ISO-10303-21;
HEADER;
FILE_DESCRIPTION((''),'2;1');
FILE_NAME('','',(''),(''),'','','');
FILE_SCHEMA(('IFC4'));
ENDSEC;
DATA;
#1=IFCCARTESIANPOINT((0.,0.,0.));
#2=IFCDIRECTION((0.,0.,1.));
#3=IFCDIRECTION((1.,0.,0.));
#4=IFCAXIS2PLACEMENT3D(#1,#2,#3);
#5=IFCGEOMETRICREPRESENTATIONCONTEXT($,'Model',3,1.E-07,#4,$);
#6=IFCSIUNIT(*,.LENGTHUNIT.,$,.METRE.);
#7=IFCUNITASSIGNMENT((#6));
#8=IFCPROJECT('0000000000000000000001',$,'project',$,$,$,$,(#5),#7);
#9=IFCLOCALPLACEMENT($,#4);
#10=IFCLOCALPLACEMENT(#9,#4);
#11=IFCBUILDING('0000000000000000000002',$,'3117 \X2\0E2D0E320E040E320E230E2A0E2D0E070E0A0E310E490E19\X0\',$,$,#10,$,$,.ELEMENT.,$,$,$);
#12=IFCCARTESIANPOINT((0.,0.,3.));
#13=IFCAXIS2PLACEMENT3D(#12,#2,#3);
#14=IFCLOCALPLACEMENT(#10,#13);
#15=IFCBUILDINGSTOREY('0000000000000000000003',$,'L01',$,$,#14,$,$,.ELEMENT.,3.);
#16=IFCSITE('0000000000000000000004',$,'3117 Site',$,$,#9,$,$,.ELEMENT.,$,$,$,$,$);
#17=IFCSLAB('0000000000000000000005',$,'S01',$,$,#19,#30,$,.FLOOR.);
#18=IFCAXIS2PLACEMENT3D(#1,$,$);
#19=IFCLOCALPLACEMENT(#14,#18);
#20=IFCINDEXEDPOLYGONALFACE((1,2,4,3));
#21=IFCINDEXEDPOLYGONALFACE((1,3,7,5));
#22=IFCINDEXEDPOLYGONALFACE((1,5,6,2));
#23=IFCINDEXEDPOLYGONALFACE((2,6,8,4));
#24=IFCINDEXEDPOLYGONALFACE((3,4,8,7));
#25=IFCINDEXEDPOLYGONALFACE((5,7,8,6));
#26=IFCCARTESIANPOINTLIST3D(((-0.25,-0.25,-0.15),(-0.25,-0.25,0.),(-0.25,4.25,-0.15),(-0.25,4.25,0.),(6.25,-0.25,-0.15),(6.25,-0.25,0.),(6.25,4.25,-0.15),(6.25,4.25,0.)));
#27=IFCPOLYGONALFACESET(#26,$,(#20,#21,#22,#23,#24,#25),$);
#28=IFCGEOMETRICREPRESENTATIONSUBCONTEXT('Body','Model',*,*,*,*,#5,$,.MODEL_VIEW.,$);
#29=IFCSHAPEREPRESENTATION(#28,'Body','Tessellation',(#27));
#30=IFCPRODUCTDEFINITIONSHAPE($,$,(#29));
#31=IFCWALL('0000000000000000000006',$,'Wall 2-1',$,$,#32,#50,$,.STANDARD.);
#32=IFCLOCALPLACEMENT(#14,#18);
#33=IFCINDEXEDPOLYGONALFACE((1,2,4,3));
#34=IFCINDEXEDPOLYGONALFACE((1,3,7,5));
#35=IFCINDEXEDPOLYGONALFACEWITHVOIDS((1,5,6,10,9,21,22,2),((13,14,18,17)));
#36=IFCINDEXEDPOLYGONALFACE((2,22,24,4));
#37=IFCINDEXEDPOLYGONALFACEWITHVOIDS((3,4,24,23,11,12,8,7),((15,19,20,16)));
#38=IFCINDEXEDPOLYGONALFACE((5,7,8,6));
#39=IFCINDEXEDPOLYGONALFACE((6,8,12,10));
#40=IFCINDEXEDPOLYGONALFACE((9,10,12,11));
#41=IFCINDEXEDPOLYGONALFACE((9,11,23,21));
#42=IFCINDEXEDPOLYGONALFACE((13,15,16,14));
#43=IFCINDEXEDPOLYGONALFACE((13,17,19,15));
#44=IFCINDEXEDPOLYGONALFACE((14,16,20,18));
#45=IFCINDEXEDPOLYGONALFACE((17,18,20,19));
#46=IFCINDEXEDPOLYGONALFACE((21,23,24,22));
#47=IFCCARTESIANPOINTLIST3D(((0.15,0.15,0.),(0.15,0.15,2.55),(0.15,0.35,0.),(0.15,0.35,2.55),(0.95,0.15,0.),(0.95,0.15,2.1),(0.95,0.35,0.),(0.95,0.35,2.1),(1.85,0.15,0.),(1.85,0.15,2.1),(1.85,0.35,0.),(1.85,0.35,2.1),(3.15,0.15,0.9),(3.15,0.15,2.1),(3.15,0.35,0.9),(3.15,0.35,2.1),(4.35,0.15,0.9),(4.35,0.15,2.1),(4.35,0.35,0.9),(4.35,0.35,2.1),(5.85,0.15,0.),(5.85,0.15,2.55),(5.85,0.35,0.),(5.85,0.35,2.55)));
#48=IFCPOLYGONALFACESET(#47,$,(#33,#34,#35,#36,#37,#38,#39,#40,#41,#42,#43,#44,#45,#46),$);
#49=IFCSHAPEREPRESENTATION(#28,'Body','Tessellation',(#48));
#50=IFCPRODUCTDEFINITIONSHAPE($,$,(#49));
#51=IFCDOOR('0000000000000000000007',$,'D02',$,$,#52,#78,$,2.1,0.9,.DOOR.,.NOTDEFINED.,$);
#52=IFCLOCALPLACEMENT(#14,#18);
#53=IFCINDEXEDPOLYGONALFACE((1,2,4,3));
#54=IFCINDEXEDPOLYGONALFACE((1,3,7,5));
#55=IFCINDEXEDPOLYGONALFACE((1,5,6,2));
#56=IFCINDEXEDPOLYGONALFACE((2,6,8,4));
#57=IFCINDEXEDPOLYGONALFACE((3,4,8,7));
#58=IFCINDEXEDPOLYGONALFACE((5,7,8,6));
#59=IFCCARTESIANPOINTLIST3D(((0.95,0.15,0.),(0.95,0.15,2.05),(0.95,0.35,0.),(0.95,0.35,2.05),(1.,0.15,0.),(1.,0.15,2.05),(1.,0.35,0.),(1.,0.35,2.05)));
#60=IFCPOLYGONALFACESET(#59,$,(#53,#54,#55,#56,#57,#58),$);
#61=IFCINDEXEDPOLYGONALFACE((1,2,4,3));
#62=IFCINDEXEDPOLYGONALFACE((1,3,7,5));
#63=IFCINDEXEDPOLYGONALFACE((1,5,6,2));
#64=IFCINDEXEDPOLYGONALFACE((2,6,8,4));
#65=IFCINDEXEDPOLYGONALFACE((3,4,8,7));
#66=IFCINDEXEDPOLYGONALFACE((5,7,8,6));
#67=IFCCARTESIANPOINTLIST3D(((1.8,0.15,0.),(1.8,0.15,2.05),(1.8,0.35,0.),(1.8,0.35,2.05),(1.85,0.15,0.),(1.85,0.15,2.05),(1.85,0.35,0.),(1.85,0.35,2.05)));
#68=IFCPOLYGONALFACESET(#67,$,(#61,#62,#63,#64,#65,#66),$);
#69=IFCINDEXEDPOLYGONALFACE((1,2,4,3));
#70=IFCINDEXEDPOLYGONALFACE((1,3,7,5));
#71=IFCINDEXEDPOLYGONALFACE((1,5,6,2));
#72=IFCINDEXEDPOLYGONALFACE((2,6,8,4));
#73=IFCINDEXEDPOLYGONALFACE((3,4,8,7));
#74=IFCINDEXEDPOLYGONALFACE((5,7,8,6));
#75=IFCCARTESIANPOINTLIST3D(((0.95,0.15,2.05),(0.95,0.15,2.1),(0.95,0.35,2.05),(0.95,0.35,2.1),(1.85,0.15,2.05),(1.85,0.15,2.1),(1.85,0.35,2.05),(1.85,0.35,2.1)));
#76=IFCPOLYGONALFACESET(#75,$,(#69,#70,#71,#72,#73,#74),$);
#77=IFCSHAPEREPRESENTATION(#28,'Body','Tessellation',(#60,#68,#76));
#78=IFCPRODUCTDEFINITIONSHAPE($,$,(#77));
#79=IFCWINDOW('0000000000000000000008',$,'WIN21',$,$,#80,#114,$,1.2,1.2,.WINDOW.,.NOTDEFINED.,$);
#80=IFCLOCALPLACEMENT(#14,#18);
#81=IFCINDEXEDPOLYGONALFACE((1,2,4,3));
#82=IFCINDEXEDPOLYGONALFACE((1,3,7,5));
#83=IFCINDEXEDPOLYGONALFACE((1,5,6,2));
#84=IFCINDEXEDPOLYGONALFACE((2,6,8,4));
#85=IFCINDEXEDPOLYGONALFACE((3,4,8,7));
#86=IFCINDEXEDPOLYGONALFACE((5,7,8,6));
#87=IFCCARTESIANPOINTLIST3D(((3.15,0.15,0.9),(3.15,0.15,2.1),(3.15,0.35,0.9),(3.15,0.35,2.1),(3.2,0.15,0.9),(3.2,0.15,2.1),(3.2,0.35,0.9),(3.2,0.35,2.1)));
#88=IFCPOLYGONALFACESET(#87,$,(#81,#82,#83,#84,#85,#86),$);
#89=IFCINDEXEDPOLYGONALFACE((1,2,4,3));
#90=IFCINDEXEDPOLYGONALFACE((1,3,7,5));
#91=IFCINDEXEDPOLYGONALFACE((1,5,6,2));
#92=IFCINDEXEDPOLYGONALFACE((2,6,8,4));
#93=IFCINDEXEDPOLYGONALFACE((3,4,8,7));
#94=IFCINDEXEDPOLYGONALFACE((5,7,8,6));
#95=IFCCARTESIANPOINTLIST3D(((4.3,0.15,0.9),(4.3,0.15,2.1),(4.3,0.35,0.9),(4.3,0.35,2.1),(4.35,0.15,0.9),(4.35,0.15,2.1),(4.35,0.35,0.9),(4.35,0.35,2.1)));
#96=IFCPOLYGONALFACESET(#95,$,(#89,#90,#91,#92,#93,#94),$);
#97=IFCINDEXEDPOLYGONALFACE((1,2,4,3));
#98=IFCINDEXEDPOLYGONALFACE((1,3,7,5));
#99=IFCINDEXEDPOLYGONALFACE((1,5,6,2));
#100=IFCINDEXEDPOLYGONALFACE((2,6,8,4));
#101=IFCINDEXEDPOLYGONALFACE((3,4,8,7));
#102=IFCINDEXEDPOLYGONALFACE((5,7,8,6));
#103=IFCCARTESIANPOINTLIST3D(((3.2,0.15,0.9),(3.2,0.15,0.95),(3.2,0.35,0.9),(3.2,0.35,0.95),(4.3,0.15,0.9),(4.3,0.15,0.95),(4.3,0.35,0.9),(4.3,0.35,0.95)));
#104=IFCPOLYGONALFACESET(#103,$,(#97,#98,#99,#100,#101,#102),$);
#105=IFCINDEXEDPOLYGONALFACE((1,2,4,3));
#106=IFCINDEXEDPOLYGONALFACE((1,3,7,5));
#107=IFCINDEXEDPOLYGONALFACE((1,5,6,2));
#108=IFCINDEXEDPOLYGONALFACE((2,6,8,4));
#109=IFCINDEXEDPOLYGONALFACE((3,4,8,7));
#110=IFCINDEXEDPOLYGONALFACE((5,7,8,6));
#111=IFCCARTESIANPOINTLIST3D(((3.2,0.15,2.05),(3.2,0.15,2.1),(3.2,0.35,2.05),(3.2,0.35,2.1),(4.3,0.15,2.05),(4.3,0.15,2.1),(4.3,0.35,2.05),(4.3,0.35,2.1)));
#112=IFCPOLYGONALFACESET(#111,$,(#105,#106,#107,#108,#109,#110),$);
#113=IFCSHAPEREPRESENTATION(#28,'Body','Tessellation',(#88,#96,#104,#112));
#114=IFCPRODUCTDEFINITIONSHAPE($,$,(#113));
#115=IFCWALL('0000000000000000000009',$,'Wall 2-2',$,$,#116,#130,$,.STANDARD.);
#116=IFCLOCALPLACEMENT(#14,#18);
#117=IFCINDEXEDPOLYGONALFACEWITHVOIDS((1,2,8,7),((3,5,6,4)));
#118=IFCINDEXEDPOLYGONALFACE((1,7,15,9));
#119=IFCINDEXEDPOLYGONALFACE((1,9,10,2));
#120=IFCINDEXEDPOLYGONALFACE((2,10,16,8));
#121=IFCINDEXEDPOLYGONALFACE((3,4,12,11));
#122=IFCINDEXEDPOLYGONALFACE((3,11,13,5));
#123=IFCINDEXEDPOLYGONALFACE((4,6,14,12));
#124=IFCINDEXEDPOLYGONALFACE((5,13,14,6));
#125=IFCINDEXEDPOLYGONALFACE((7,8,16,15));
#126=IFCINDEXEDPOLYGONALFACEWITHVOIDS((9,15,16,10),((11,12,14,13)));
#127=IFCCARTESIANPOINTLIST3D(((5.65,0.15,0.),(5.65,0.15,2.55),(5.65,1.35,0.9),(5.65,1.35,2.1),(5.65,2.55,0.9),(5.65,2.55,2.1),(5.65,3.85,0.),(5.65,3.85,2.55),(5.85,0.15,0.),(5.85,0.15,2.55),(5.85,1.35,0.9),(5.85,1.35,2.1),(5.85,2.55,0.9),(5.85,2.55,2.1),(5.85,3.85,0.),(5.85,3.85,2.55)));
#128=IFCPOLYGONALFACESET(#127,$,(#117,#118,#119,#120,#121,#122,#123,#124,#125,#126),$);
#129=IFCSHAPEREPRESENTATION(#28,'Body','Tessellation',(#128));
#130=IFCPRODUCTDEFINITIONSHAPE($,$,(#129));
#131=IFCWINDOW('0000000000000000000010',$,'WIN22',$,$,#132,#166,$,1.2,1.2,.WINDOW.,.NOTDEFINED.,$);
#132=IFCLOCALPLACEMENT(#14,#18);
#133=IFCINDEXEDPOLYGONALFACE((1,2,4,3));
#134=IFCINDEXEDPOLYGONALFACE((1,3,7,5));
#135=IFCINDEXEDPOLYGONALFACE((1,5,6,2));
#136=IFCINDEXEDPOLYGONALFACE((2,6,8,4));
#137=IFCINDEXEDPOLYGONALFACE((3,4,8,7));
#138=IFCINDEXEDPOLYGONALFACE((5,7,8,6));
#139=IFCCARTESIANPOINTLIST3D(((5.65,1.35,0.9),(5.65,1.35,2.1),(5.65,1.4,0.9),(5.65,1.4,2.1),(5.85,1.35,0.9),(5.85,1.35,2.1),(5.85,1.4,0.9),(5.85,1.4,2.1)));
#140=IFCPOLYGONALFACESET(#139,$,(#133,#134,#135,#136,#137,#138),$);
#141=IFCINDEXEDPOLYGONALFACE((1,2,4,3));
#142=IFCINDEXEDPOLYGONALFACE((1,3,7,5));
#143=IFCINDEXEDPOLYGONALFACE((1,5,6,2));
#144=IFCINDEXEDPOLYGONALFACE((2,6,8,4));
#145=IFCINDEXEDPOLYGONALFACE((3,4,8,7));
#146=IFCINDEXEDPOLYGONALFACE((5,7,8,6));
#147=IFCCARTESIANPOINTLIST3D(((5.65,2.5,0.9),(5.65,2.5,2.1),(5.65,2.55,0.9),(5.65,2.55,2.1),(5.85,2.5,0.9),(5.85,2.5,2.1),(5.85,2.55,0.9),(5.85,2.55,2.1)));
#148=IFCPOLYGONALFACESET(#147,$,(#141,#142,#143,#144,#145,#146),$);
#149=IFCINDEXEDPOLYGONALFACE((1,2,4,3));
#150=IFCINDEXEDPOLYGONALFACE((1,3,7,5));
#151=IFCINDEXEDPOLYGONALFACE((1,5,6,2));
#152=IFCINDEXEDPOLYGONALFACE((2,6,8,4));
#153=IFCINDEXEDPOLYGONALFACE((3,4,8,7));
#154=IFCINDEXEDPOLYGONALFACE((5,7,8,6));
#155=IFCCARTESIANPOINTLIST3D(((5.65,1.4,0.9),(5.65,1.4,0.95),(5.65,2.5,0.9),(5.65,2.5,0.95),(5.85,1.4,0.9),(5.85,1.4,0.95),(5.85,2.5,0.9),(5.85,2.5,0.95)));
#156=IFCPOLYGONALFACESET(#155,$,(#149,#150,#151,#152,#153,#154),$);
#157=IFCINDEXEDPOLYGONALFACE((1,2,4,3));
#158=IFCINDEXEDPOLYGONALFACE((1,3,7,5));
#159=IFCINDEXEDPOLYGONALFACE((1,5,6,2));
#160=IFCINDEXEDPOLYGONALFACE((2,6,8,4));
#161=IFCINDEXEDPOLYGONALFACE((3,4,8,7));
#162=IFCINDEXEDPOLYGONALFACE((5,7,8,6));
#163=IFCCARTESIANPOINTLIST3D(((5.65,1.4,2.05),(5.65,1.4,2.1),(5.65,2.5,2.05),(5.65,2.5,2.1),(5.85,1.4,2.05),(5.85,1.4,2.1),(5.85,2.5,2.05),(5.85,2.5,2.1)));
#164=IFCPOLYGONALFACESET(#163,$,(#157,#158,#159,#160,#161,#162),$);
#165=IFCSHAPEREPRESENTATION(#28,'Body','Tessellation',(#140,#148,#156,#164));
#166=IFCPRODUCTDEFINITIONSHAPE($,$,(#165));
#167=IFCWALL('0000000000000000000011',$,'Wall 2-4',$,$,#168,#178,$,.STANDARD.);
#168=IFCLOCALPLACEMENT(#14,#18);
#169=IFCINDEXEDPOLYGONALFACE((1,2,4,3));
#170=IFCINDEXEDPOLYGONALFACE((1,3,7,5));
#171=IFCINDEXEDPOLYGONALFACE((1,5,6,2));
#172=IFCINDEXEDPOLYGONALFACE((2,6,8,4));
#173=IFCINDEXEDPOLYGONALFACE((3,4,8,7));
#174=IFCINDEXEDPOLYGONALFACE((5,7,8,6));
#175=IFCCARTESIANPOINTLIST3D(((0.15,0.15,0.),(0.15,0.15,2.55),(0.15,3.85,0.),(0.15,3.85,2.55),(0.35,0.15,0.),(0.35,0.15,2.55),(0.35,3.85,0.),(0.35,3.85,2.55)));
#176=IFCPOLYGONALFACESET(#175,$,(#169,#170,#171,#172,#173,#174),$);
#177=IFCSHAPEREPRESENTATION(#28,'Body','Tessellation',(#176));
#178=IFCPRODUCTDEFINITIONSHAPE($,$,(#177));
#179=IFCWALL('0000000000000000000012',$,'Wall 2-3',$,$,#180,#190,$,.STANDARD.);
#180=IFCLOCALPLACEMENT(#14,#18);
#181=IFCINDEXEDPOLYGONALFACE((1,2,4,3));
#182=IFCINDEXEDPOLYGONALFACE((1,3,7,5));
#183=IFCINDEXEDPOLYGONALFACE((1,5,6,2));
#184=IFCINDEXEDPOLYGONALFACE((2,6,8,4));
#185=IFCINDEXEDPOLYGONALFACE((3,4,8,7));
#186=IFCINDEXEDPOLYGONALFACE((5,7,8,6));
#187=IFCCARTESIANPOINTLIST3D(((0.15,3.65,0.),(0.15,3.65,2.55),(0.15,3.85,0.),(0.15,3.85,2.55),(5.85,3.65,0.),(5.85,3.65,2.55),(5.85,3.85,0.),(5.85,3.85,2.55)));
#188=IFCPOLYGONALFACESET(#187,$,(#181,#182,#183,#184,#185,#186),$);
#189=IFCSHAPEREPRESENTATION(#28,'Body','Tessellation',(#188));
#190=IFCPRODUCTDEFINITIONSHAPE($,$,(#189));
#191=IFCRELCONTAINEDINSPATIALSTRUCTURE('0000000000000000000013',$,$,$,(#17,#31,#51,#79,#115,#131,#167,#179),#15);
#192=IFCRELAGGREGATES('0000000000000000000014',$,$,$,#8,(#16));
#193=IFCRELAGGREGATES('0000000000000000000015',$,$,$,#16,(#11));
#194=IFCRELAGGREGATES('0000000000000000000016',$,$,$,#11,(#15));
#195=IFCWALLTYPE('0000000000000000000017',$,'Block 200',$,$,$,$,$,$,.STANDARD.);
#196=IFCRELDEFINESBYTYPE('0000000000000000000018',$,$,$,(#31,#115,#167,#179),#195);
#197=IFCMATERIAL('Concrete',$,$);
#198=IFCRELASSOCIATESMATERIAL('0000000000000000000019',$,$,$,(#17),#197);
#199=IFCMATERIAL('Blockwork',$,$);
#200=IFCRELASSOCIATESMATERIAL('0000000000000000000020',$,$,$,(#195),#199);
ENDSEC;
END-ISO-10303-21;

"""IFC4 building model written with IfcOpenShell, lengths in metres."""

from ifc_helpers import new_model, si_unit, frame, origin_with_axes, place, context, subcontext, project, spatial, polyline, outline, extrude, material, type_object, element, fill, save


model = new_model("IFC4")

# Units and contexts
model_context = context("Model", 3, precision=1e-07, world=origin_with_axes())
body_context = subcontext(model_context, "Body", "Model", "MODEL_VIEW")
ifc_project = project(units=[si_unit("LENGTHUNIT", "METRE")], contexts=[model_context])

# Site, building, storey
site_placement = place(None, origin_with_axes())
site = spatial("IfcSite", under=ifc_project, at=site_placement, Name="3117 Site", CompositionType="ELEMENT")
building_placement = place(site_placement, origin_with_axes())
building = spatial("IfcBuilding", under=site, at=building_placement, Name="3117 อาคารสองชั้น", CompositionType="ELEMENT")
storey_placement = place(building_placement, frame((0.0, 0.0, 3.0), z_axis=(0.0, 0.0, 1.0), x_axis=(1.0, 0.0, 0.0)))
storey = spatial("IfcBuildingStorey", under=building, at=storey_placement, Name="L01", CompositionType="ELEMENT", Elevation=3.0)

# Slab
ifc_material_1 = material(Name="Concrete")
slab_placement = place(storey_placement, frame((0.0, 0.0, -0.15), z_axis=(0.0, 0.0, 1.0), x_axis=(1.0, 0.0, 0.0)))
element("IfcSlab", 1, at=slab_placement, inside=storey, material=ifc_material_1, Name="S01", PredefinedType="FLOOR", context=body_context, shape_type="SweptSolid", body=[
    extrude(outline(polyline([(-0.25, -0.25), (6.25, -0.25), (6.25, 4.25), (-0.25, 4.25), (-0.25, -0.25)])), origin_with_axes(), (0.0, 0.0, 1.0), 0.15),
])

# Wall, openings, door, window
ifc_material_2 = material(Name="Blockwork")
wall_type = type_object("IfcWallType", Name="Block 200", PredefinedType="STANDARD", material=ifc_material_2)
wall_1_placement = place(storey_placement, frame((0.15, 0.15, 0.0), z_axis=(0.0, 0.0, 1.0), x_axis=(1.0, 0.0, 0.0)))
wall_1 = element("IfcWall", 2, at=wall_1_placement, inside=storey, type_object=wall_type, Name="Wall 2-1", PredefinedType="STANDARD", context=body_context, shape_type="SweptSolid", body=[
    extrude(outline(polyline([(0.0, 0.0), (5.7, 0.0), (5.7, 0.2), (0.0, 0.2), (0.0, 0.0)])), origin_with_axes(), (0.0, 0.0, 1.0), 2.55),
])
opening_1_placement = place(wall_1_placement, frame((0.8, 0.0, 0.0), z_axis=(0.0, 0.0, 1.0), x_axis=(1.0, 0.0, 0.0)))
opening_1 = element("IfcOpeningElement", 3, at=opening_1_placement, cuts=wall_1, PredefinedType="OPENING", context=body_context, shape_type="SweptSolid", body=[
    extrude(outline(polyline([(0.0, 0.0), (0.9, 0.0), (0.9, 0.2), (0.0, 0.2), (0.0, 0.0)])), origin_with_axes(), (0.0, 0.0, 1.0), 2.1),
])
opening_2_placement = place(wall_1_placement, frame((3.0, 0.0, 0.9), z_axis=(0.0, 0.0, 1.0), x_axis=(1.0, 0.0, 0.0)))
opening_2 = element("IfcOpeningElement", 4, at=opening_2_placement, cuts=wall_1, PredefinedType="OPENING", context=body_context, shape_type="SweptSolid", body=[
    extrude(outline(polyline([(0.0, 0.0), (1.2, 0.0), (1.2, 0.2), (0.0, 0.2), (0.0, 0.0)])), origin_with_axes(), (0.0, 0.0, 1.0), 1.2),
])
door_placement = place(opening_1_placement, frame((0.0, 0.0, 0.0), z_axis=(0.0, 0.0, 1.0), x_axis=(1.0, 0.0, 0.0)))
door = element("IfcDoor", 5, at=door_placement, inside=storey, Name="D02", OperationType="NOTDEFINED", OverallHeight=2.1, OverallWidth=0.9, PredefinedType="DOOR", context=body_context, shape_type="SweptSolid", body=[
    extrude(outline(polyline([(0.0, 0.0), (0.05, 0.0), (0.05, 0.2), (0.0, 0.2), (0.0, 0.0)])), origin_with_axes(), (0.0, 0.0, 1.0), 2.05),
    extrude(outline(polyline([(0.0, 0.0), (0.05, 0.0), (0.05, 0.2), (0.0, 0.2), (0.0, 0.0)])), frame((0.85, 0.0, 0.0), z_axis=(0.0, 0.0, 1.0), x_axis=(1.0, 0.0, 0.0)), (0.0, 0.0, 1.0), 2.05),
    extrude(outline(polyline([(0.0, 0.0), (0.9, 0.0), (0.9, 0.2), (0.0, 0.2), (0.0, 0.0)])), frame((0.0, 0.0, 2.05), z_axis=(0.0, 0.0, 1.0), x_axis=(1.0, 0.0, 0.0)), (0.0, 0.0, 1.0), 0.05),
])
fill(opening_1, door)
window_1_placement = place(opening_2_placement, frame((0.0, 0.0, 0.0), z_axis=(0.0, 0.0, 1.0), x_axis=(1.0, 0.0, 0.0)))
window_1 = element("IfcWindow", 6, at=window_1_placement, inside=storey, Name="WIN21", OverallHeight=1.2, OverallWidth=1.2, PartitioningType="NOTDEFINED", PredefinedType="WINDOW", context=body_context, shape_type="SweptSolid", body=[
    extrude(outline(polyline([(0.0, 0.0), (0.05, 0.0), (0.05, 0.2), (0.0, 0.2), (0.0, 0.0)])), origin_with_axes(), (0.0, 0.0, 1.0), 1.2),
    extrude(outline(polyline([(0.0, 0.0), (0.05, 0.0), (0.05, 0.2), (0.0, 0.2), (0.0, 0.0)])), frame((1.15, 0.0, 0.0), z_axis=(0.0, 0.0, 1.0), x_axis=(1.0, 0.0, 0.0)), (0.0, 0.0, 1.0), 1.2),
    extrude(outline(polyline([(0.0, 0.0), (1.1, 0.0), (1.1, 0.2), (0.0, 0.2), (0.0, 0.0)])), frame((0.05, 0.0, 0.0), z_axis=(0.0, 0.0, 1.0), x_axis=(1.0, 0.0, 0.0)), (0.0, 0.0, 1.0), 0.05),
    extrude(outline(polyline([(0.0, 0.0), (1.1, 0.0), (1.1, 0.2), (0.0, 0.2), (0.0, 0.0)])), frame((0.05, 0.0, 1.15), z_axis=(0.0, 0.0, 1.0), x_axis=(1.0, 0.0, 0.0)), (0.0, 0.0, 1.0), 0.05),
])
fill(opening_2, window_1)

# Wall, opening, window
wall_2_placement = place(storey_placement, frame((5.85, 0.15, 0.0), z_axis=(0.0, 0.0, 1.0), x_axis=(0.0, 1.0, 0.0)))
wall_2 = element("IfcWall", 7, at=wall_2_placement, inside=storey, type_object=wall_type, Name="Wall 2-2", PredefinedType="STANDARD", context=body_context, shape_type="SweptSolid", body=[
    extrude(outline(polyline([(0.0, 0.0), (3.7, 0.0), (3.7, 0.2), (0.0, 0.2), (0.0, 0.0)])), origin_with_axes(), (0.0, 0.0, 1.0), 2.55),
])
opening_3_placement = place(wall_2_placement, frame((1.2, 0.0, 0.9), z_axis=(0.0, 0.0, 1.0), x_axis=(1.0, 0.0, 0.0)))
opening_3 = element("IfcOpeningElement", 8, at=opening_3_placement, cuts=wall_2, PredefinedType="OPENING", context=body_context, shape_type="SweptSolid", body=[
    extrude(outline(polyline([(0.0, 0.0), (1.2, 0.0), (1.2, 0.2), (0.0, 0.2), (0.0, 0.0)])), origin_with_axes(), (0.0, 0.0, 1.0), 1.2),
])
window_2_placement = place(opening_3_placement, frame((0.0, 0.0, 0.0), z_axis=(0.0, 0.0, 1.0), x_axis=(1.0, 0.0, 0.0)))
window_2 = element("IfcWindow", 9, at=window_2_placement, inside=storey, Name="WIN22", OverallHeight=1.2, OverallWidth=1.2, PartitioningType="NOTDEFINED", PredefinedType="WINDOW", context=body_context, shape_type="SweptSolid", body=[
    extrude(outline(polyline([(0.0, 0.0), (0.05, 0.0), (0.05, 0.2), (0.0, 0.2), (0.0, 0.0)])), origin_with_axes(), (0.0, 0.0, 1.0), 1.2),
    extrude(outline(polyline([(0.0, 0.0), (0.05, 0.0), (0.05, 0.2), (0.0, 0.2), (0.0, 0.0)])), frame((1.15, 0.0, 0.0), z_axis=(0.0, 0.0, 1.0), x_axis=(1.0, 0.0, 0.0)), (0.0, 0.0, 1.0), 1.2),
    extrude(outline(polyline([(0.0, 0.0), (1.1, 0.0), (1.1, 0.2), (0.0, 0.2), (0.0, 0.0)])), frame((0.05, 0.0, 0.0), z_axis=(0.0, 0.0, 1.0), x_axis=(1.0, 0.0, 0.0)), (0.0, 0.0, 1.0), 0.05),
    extrude(outline(polyline([(0.0, 0.0), (1.1, 0.0), (1.1, 0.2), (0.0, 0.2), (0.0, 0.0)])), frame((0.05, 0.0, 1.15), z_axis=(0.0, 0.0, 1.0), x_axis=(1.0, 0.0, 0.0)), (0.0, 0.0, 1.0), 0.05),
])
fill(opening_3, window_2)

# Walls
wall_3_placement = place(storey_placement, frame((0.15, 3.85, 0.0), z_axis=(0.0, 0.0, 1.0), x_axis=(0.0, -1.0, 0.0)))
element("IfcWall", 10, at=wall_3_placement, inside=storey, type_object=wall_type, Name="Wall 2-4", PredefinedType="STANDARD", context=body_context, shape_type="SweptSolid", body=[
    extrude(outline(polyline([(0.0, 0.0), (3.7, 0.0), (3.7, 0.2), (0.0, 0.2), (0.0, 0.0)])), origin_with_axes(), (0.0, 0.0, 1.0), 2.55),
])
wall_4_placement = place(storey_placement, frame((5.85, 3.85, 0.0), z_axis=(0.0, 0.0, 1.0), x_axis=(-1.0, 0.0, 0.0)))
element("IfcWall", 11, at=wall_4_placement, inside=storey, type_object=wall_type, Name="Wall 2-3", PredefinedType="STANDARD", context=body_context, shape_type="SweptSolid", body=[
    extrude(outline(polyline([(0.0, 0.0), (5.7, 0.0), (5.7, 0.2), (0.0, 0.2), (0.0, 0.0)])), origin_with_axes(), (0.0, 0.0, 1.0), 2.55),
])

save(model, "model.ifc")
